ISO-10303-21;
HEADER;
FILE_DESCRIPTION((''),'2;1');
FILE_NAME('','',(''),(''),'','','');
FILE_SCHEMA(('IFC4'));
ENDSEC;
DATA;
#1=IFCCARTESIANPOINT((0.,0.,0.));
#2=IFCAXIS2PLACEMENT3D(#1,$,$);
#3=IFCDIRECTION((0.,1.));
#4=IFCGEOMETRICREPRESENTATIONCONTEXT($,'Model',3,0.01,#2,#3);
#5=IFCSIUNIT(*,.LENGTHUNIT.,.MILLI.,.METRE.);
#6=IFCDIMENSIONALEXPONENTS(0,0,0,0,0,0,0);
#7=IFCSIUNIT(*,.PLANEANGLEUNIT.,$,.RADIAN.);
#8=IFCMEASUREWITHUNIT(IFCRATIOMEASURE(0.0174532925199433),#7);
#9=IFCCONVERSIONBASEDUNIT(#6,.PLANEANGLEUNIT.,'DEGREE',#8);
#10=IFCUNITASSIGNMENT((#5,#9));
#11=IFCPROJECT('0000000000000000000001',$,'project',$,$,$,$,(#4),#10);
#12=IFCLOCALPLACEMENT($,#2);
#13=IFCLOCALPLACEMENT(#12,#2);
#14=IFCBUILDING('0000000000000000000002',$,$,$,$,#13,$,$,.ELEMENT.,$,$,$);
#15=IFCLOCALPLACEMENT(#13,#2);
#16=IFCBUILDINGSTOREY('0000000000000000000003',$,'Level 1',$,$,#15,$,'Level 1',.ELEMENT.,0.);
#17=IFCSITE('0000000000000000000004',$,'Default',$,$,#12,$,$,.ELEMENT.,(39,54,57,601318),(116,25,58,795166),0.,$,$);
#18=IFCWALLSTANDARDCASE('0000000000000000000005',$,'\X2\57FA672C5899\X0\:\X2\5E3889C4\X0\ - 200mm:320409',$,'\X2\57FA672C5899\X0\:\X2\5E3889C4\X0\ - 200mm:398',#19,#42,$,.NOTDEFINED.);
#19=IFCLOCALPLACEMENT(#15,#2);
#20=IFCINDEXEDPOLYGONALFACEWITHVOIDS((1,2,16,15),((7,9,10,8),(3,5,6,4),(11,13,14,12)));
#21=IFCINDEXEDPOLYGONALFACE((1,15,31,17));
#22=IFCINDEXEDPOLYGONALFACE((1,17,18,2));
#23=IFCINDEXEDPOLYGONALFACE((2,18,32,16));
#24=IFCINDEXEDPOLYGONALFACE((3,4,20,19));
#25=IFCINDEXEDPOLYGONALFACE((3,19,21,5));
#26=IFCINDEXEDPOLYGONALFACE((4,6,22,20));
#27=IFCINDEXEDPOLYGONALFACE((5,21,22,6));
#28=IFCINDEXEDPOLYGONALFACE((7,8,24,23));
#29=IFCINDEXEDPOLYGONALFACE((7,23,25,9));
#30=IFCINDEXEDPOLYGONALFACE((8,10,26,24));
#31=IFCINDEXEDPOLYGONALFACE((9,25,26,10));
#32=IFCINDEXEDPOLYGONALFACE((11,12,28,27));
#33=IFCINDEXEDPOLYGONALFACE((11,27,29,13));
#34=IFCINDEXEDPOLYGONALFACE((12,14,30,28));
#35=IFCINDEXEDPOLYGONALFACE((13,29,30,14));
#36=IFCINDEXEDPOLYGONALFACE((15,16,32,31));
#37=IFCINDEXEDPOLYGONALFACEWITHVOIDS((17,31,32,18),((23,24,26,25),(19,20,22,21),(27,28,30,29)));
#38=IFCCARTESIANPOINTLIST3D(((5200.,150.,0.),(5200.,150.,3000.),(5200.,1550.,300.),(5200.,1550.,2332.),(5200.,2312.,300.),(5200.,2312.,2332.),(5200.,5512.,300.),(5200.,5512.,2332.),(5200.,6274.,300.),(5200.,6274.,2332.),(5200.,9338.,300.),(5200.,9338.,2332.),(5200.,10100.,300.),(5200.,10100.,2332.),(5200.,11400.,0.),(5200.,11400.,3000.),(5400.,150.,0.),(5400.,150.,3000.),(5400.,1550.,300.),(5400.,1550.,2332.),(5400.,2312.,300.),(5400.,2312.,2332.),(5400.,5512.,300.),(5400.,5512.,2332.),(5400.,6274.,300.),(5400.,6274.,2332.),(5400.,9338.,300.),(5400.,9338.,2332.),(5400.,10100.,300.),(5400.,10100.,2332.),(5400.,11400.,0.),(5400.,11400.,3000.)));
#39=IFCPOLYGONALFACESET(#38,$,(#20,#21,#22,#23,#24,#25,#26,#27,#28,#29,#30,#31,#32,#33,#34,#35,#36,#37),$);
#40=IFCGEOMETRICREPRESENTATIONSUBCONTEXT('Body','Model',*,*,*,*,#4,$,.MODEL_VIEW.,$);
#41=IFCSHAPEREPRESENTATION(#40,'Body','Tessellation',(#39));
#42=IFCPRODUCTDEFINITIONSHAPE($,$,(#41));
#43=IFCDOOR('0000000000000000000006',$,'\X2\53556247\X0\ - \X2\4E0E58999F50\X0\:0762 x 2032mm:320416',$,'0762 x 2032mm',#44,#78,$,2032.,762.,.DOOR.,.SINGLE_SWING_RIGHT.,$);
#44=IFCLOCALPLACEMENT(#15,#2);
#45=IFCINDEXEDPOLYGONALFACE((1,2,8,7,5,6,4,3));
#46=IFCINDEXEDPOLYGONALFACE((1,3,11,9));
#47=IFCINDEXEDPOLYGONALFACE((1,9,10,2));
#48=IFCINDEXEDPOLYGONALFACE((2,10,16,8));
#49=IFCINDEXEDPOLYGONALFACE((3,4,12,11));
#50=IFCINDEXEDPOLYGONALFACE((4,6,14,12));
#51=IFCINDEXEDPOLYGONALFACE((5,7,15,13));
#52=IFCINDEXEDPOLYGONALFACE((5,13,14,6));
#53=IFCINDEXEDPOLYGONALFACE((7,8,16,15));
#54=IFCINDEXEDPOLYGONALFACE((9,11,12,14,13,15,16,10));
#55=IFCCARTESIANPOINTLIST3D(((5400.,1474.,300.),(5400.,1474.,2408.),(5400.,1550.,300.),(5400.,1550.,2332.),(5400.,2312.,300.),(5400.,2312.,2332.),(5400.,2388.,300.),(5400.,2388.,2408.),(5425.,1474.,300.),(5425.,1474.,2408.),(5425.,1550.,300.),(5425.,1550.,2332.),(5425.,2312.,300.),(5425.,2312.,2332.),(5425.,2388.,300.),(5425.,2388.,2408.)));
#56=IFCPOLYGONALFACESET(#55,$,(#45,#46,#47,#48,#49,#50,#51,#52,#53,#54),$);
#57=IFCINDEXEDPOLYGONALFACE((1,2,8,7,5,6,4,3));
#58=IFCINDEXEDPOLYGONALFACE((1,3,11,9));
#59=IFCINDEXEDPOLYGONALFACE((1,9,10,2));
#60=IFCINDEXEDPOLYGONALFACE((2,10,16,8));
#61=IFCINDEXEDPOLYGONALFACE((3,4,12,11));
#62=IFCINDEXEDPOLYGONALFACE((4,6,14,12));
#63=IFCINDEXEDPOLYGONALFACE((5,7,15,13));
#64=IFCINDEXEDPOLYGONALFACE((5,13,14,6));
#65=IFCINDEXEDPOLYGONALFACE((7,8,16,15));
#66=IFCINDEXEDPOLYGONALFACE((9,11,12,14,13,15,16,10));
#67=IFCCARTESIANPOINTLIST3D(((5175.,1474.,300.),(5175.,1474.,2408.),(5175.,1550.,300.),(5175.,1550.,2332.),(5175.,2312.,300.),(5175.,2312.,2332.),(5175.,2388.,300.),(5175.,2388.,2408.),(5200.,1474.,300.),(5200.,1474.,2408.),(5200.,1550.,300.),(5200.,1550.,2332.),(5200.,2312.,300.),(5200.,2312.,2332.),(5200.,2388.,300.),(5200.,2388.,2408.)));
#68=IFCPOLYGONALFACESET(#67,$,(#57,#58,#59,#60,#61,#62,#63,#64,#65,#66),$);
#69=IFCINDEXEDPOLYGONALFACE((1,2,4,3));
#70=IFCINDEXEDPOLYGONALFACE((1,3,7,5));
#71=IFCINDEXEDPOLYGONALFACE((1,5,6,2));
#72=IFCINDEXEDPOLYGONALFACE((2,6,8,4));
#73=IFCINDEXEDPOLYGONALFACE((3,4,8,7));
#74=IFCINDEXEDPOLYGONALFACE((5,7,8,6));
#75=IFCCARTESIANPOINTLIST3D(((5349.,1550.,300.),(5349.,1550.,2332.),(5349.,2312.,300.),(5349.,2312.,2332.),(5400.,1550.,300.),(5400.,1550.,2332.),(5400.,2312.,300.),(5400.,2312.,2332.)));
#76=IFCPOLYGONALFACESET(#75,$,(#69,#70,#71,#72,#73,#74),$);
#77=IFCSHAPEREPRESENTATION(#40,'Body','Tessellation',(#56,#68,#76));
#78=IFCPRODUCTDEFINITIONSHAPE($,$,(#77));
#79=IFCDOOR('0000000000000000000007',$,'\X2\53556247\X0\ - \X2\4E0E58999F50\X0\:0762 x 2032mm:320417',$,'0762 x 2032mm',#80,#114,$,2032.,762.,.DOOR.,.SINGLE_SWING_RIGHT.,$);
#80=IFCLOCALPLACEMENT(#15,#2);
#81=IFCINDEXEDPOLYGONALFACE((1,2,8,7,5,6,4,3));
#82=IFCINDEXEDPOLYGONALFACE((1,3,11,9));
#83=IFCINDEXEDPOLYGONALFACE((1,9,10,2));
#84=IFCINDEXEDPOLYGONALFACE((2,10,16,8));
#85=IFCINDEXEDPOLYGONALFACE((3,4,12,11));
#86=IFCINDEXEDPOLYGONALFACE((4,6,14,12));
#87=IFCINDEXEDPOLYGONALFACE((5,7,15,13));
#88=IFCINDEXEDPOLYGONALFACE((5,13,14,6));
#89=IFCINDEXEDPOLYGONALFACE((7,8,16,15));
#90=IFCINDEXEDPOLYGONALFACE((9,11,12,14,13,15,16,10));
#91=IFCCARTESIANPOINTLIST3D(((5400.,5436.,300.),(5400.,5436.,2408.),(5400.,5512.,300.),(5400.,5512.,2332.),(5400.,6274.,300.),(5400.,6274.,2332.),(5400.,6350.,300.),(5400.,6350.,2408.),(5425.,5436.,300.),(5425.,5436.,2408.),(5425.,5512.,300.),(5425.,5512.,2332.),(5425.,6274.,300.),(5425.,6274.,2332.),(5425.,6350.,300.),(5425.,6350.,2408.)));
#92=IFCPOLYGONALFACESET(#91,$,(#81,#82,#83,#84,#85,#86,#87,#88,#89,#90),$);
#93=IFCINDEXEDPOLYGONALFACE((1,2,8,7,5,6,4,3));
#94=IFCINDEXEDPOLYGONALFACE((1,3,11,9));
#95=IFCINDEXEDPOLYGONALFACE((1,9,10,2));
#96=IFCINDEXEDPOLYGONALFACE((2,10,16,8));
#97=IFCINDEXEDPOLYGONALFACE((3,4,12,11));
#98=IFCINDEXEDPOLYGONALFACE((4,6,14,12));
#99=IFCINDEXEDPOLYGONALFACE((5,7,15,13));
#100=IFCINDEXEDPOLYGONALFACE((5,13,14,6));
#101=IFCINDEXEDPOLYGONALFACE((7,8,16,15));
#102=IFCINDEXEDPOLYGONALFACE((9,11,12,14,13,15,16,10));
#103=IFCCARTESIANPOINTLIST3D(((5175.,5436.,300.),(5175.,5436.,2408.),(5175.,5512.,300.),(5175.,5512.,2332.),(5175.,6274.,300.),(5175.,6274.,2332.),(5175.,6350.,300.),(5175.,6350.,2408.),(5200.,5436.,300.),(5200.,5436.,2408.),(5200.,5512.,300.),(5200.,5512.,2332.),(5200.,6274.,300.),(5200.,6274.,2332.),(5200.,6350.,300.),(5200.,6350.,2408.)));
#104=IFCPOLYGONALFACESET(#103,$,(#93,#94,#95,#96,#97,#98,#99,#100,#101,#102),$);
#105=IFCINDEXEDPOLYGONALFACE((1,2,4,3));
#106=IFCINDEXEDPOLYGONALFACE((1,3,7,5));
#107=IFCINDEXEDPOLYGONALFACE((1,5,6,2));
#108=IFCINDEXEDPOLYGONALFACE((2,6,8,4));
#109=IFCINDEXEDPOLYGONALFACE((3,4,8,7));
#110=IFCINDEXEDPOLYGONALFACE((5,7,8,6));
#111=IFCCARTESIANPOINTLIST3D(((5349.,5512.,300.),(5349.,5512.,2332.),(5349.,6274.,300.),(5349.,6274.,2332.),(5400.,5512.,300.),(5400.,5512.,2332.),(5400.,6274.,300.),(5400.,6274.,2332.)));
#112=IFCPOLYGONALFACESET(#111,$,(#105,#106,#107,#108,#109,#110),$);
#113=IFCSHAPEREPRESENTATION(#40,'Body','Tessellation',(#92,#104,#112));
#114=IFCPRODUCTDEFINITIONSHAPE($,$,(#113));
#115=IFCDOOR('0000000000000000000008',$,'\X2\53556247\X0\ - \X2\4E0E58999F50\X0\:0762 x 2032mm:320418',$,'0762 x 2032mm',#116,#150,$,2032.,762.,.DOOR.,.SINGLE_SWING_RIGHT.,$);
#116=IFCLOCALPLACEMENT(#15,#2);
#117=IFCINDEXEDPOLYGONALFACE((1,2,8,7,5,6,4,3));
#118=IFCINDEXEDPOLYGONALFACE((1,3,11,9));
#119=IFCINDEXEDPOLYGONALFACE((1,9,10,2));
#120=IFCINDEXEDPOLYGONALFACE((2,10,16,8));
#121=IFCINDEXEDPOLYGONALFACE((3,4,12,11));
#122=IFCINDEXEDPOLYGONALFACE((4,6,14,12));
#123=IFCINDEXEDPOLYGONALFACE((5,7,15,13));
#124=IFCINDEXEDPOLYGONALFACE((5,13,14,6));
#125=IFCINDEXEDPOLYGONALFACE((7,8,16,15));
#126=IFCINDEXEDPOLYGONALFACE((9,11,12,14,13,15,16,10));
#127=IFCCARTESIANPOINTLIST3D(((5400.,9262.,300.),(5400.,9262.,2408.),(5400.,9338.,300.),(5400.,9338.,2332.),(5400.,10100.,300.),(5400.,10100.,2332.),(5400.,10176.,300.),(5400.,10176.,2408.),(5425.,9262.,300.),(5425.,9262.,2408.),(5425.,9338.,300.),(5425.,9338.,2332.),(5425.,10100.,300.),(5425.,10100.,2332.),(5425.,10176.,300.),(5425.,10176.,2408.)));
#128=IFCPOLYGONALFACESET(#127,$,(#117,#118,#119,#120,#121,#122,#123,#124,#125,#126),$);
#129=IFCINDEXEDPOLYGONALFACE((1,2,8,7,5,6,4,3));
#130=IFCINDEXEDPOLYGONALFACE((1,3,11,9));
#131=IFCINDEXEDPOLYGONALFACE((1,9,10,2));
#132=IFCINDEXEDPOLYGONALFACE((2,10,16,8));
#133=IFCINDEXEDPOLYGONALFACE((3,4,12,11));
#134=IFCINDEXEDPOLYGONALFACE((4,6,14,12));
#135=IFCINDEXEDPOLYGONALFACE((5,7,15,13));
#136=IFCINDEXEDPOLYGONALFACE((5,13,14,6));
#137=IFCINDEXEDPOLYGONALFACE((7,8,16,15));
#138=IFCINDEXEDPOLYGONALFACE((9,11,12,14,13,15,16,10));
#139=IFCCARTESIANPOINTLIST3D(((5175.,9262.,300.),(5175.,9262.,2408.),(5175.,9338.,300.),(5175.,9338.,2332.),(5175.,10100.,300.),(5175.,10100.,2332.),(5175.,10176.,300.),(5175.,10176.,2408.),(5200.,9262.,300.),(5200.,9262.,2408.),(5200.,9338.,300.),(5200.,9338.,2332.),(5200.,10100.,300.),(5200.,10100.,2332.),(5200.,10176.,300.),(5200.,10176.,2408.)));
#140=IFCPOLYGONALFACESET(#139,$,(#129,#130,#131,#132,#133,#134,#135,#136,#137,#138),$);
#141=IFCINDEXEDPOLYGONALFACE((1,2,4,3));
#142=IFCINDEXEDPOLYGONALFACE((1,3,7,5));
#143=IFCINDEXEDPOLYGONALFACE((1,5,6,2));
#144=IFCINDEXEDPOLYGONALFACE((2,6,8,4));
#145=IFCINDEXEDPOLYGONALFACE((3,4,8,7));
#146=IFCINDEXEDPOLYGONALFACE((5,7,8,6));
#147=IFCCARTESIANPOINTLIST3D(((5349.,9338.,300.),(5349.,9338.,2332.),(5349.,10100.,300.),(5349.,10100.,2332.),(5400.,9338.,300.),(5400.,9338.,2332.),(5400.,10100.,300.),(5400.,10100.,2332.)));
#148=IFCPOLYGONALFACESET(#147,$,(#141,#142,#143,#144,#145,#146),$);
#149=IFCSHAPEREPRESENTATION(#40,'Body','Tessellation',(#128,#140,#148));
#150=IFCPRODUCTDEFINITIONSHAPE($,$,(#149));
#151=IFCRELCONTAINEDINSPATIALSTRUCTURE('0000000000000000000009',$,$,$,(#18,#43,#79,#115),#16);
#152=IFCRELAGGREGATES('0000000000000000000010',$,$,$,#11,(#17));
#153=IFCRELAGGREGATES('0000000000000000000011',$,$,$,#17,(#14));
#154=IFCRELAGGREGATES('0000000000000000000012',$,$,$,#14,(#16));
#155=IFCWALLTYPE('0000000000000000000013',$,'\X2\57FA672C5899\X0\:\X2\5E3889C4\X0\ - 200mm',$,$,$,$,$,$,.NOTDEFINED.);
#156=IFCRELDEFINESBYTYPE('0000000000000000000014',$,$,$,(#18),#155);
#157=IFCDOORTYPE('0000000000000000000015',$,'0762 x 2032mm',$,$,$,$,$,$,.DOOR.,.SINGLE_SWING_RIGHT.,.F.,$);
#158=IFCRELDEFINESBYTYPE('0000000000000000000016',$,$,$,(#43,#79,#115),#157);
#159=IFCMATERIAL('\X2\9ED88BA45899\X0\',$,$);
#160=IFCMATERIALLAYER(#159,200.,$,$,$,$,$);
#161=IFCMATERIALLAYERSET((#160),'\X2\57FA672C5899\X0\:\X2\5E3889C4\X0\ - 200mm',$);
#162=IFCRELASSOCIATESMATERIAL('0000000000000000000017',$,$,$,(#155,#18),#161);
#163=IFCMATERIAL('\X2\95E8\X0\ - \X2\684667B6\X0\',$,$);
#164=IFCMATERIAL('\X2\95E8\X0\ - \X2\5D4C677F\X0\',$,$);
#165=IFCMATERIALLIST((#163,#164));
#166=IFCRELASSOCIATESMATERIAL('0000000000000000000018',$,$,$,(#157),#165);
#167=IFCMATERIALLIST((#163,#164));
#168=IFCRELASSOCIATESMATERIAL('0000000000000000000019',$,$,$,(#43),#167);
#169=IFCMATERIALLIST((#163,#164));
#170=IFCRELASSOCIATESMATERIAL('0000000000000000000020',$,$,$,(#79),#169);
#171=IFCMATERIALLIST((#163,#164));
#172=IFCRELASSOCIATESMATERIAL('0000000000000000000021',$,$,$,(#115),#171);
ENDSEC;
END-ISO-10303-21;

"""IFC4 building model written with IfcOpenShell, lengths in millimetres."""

from ifc_helpers import new_model, entity, si_unit, converted_unit, direction, frame, frame_2d, origin, place, context, subcontext, project, spatial, polyline, rectangle, outline, extrude, source, transform, mapped, material, material_list, layer, layer_set, layer_usage, type_object, type_shapes, element, fill, save


model = new_model("IFC4")

# Units and contexts
model_context = context("Model", 3, precision=0.01, world=origin(), true_north=direction((0.0, 1.0)))
body_context = subcontext(model_context, "Body", "Model", "MODEL_VIEW")
ifc_project = project(units=[si_unit("LENGTHUNIT", "METRE", prefix="MILLI"), converted_unit("PLANEANGLEUNIT", "DEGREE", entity("IfcRatioMeasure", 0.0174532925199433), si_unit("PLANEANGLEUNIT", "RADIAN"), dimensions=[0, 0, 0, 0, 0, 0, 0])], contexts=[model_context])

# Site, building, storey
site_placement = place(None, origin())
site = spatial("IfcSite", under=ifc_project, at=site_placement, Name="Default", CompositionType="ELEMENT", RefLatitude=(39, 54, 57, 601318), RefLongitude=(116, 25, 58, 795166), RefElevation=0.0)
building_placement = place(site_placement, origin())
building = spatial("IfcBuilding", under=site, at=building_placement, CompositionType="ELEMENT")
storey_placement = place(building_placement, origin())
storey = spatial("IfcBuildingStorey", under=building, at=storey_placement, Name="Level 1", LongName="Level 1", CompositionType="ELEMENT", Elevation=0.0)

# Shared definitions
ifc_material_1 = material(Name="默认墙")
ifc_layer = layer(ifc_material_1, 200.0)
ifc_layer_set = layer_set([ifc_layer], Name="基本墙:常规 - 200mm")
wall_type = type_object("IfcWallType", Name="基本墙:常规 - 200mm", PredefinedType="NOTDEFINED", material=ifc_layer_set)

# Wall, openings, doors
ifc_layer_usage_1 = layer_usage(ifc_layer_set, "AXIS2", "NEGATIVE", 100.0)
wall_1_placement = place(storey_placement, frame((5300.0, 11400.0, 0.0), z_axis=(0.0, 0.0, 1.0), x_axis=(0.0, -1.0, 0.0)))
wall_1 = element("IfcWallStandardCase", 1, at=wall_1_placement, inside=storey, type_object=wall_type, material=ifc_layer_usage_1, Name="基本墙:常规 - 200mm:320409", ObjectType="基本墙:常规 - 200mm:398", PredefinedType="NOTDEFINED", context=body_context, shape_type="SweptSolid", body=[
    extrude(rectangle(XDim=11250.0, YDim=200.0, at=frame_2d((5625.0, 0.0), x_axis=(-1.0, 0.0))), origin(), (0.0, 0.0, 1.0), 3000.0),
])
opening_1_placement = place(wall_1_placement, frame((9088.0, -100.0, 300.0)))
opening_1 = element("IfcOpeningElement", 2, at=opening_1_placement, cuts=wall_1, ObjectType="Opening", PredefinedType="OPENING", context=body_context, shape_type="SweptSolid", body=[
    extrude(rectangle(XDim=762.0, YDim=2032.0, at=frame_2d((1016.0, 381.0), x_axis=(0.0, 1.0))), frame((0.0, 0.0, 0.0), z_axis=(0.0, 1.0, 0.0), x_axis=(0.0, 0.0, 1.0)), (0.0, 0.0, 1.0), 200.0),
])
opening_2_placement = place(wall_1_placement, frame((5126.0, -100.0, 300.0)))
opening_2 = element("IfcOpeningElement", 3, at=opening_2_placement, cuts=wall_1, ObjectType="Opening", PredefinedType="OPENING", context=body_context, shape_type="SweptSolid", body=[
    extrude(rectangle(XDim=762.0, YDim=2032.0, at=frame_2d((1016.0, 381.0), x_axis=(0.0, 1.0))), frame((0.0, 0.0, 0.0), z_axis=(0.0, 1.0, 0.0), x_axis=(0.0, 0.0, 1.0)), (0.0, 0.0, 1.0), 200.0),
])
opening_3_placement = place(wall_1_placement, frame((1300.0, -100.0, 300.0)))
opening_3 = element("IfcOpeningElement", 4, at=opening_3_placement, cuts=wall_1, ObjectType="Opening", PredefinedType="OPENING", context=body_context, shape_type="SweptSolid", body=[
    extrude(rectangle(XDim=762.0, YDim=2032.0, at=frame_2d((1016.0, 381.0), x_axis=(0.0, 1.0))), frame((0.0, 0.0, 0.0), z_axis=(0.0, 1.0, 0.0), x_axis=(0.0, 0.0, 1.0)), (0.0, 0.0, 1.0), 200.0),
])
ifc_material_2 = material(Name="门 - 框架")
ifc_material_3 = material(Name="门 - 嵌板")
ifc_material_list_1 = material_list([ifc_material_2, ifc_material_3])
ifc_material_list_2 = material_list([ifc_material_2, ifc_material_3])
door_type_1 = type_object("IfcDoorType", Name="0762 x 2032mm", OperationType="SINGLE_SWING_RIGHT", ParameterTakesPrecedence=False, PredefinedType="DOOR", material=ifc_material_list_2)
shared_shape_1 = source(origin(), body_context, "Body", "SweptSolid", [
    extrude(outline(polyline([(-457.0, -1073.0), (457.0, -1073.0), (457.0, 1035.0), (381.0, 1035.0), (381.0, -997.0), (-381.0, -997.0), (-381.0, 1035.0), (-457.0, 1035.0), (-457.0, -1073.0)])), frame((381.0, 200.0, 1035.0), z_axis=(0.0, 1.0, 0.0), x_axis=(1.0, 0.0, 0.0)), (0.0, 0.0, 1.0), 25.0),
    extrude(outline(polyline([(-1073.0, -457.0), (1035.0, -457.0), (1035.0, -381.0), (-997.0, -381.0), (-997.0, 381.0), (1035.0, 381.0), (1035.0, 457.0), (-1073.0, 457.0), (-1073.0, -457.0)])), frame((381.0, -25.0, 1035.0), z_axis=(0.0, 1.0, 0.0), x_axis=(0.0, 0.0, -1.0)), (0.0, 0.0, 1.0), 25.0),
    extrude(rectangle(XDim=51.0, YDim=762.0, at=frame_2d((0.0, 0.0), x_axis=(1.0, 0.0))), frame((381.0, 174.5, 0.0), z_axis=(0.0, 0.0, 1.0), x_axis=(0.0, 1.0, 0.0)), (0.0, 0.0, 1.0), 2032.0),
])
type_shapes(door_type_1, [shared_shape_1])
door_1_placement = place(opening_1_placement, origin())
door_1 = element("IfcDoor", 5, at=door_1_placement, inside=storey, type_object=door_type_1, material=ifc_material_list_1, Name="单扇 - 与墙齐:0762 x 2032mm:320416", ObjectType="0762 x 2032mm", OperationType="SINGLE_SWING_RIGHT", OverallHeight=2032.0, OverallWidth=762.0, PredefinedType="DOOR", context=body_context, shape_type="MappedRepresentation", body=[
    mapped(shared_shape_1, transform((0.0, 0.0, 0.0), scale=1.0)),
])
fill(opening_1, door_1)
ifc_material_list_3 = material_list([ifc_material_2, ifc_material_3])
door_2_placement = place(opening_2_placement, origin())
door_2 = element("IfcDoor", 6, at=door_2_placement, inside=storey, type_object=door_type_1, material=ifc_material_list_3, Name="单扇 - 与墙齐:0762 x 2032mm:320417", ObjectType="0762 x 2032mm", OperationType="SINGLE_SWING_RIGHT", OverallHeight=2032.0, OverallWidth=762.0, PredefinedType="DOOR", context=body_context, shape_type="MappedRepresentation", body=[
    mapped(shared_shape_1, transform((0.0, 0.0, 0.0), scale=1.0)),
])
fill(opening_2, door_2)
ifc_material_list_4 = material_list([ifc_material_2, ifc_material_3])
door_3_placement = place(opening_3_placement, origin())
door_3 = element("IfcDoor", 7, at=door_3_placement, inside=storey, type_object=door_type_1, material=ifc_material_list_4, Name="单扇 - 与墙齐:0762 x 2032mm:320418", ObjectType="0762 x 2032mm", OperationType="SINGLE_SWING_RIGHT", OverallHeight=2032.0, OverallWidth=762.0, PredefinedType="DOOR", context=body_context, shape_type="MappedRepresentation", body=[
    mapped(shared_shape_1, transform((0.0, 0.0, 0.0), scale=1.0)),
])
fill(opening_3, door_3)

save(model, "model.ifc")
